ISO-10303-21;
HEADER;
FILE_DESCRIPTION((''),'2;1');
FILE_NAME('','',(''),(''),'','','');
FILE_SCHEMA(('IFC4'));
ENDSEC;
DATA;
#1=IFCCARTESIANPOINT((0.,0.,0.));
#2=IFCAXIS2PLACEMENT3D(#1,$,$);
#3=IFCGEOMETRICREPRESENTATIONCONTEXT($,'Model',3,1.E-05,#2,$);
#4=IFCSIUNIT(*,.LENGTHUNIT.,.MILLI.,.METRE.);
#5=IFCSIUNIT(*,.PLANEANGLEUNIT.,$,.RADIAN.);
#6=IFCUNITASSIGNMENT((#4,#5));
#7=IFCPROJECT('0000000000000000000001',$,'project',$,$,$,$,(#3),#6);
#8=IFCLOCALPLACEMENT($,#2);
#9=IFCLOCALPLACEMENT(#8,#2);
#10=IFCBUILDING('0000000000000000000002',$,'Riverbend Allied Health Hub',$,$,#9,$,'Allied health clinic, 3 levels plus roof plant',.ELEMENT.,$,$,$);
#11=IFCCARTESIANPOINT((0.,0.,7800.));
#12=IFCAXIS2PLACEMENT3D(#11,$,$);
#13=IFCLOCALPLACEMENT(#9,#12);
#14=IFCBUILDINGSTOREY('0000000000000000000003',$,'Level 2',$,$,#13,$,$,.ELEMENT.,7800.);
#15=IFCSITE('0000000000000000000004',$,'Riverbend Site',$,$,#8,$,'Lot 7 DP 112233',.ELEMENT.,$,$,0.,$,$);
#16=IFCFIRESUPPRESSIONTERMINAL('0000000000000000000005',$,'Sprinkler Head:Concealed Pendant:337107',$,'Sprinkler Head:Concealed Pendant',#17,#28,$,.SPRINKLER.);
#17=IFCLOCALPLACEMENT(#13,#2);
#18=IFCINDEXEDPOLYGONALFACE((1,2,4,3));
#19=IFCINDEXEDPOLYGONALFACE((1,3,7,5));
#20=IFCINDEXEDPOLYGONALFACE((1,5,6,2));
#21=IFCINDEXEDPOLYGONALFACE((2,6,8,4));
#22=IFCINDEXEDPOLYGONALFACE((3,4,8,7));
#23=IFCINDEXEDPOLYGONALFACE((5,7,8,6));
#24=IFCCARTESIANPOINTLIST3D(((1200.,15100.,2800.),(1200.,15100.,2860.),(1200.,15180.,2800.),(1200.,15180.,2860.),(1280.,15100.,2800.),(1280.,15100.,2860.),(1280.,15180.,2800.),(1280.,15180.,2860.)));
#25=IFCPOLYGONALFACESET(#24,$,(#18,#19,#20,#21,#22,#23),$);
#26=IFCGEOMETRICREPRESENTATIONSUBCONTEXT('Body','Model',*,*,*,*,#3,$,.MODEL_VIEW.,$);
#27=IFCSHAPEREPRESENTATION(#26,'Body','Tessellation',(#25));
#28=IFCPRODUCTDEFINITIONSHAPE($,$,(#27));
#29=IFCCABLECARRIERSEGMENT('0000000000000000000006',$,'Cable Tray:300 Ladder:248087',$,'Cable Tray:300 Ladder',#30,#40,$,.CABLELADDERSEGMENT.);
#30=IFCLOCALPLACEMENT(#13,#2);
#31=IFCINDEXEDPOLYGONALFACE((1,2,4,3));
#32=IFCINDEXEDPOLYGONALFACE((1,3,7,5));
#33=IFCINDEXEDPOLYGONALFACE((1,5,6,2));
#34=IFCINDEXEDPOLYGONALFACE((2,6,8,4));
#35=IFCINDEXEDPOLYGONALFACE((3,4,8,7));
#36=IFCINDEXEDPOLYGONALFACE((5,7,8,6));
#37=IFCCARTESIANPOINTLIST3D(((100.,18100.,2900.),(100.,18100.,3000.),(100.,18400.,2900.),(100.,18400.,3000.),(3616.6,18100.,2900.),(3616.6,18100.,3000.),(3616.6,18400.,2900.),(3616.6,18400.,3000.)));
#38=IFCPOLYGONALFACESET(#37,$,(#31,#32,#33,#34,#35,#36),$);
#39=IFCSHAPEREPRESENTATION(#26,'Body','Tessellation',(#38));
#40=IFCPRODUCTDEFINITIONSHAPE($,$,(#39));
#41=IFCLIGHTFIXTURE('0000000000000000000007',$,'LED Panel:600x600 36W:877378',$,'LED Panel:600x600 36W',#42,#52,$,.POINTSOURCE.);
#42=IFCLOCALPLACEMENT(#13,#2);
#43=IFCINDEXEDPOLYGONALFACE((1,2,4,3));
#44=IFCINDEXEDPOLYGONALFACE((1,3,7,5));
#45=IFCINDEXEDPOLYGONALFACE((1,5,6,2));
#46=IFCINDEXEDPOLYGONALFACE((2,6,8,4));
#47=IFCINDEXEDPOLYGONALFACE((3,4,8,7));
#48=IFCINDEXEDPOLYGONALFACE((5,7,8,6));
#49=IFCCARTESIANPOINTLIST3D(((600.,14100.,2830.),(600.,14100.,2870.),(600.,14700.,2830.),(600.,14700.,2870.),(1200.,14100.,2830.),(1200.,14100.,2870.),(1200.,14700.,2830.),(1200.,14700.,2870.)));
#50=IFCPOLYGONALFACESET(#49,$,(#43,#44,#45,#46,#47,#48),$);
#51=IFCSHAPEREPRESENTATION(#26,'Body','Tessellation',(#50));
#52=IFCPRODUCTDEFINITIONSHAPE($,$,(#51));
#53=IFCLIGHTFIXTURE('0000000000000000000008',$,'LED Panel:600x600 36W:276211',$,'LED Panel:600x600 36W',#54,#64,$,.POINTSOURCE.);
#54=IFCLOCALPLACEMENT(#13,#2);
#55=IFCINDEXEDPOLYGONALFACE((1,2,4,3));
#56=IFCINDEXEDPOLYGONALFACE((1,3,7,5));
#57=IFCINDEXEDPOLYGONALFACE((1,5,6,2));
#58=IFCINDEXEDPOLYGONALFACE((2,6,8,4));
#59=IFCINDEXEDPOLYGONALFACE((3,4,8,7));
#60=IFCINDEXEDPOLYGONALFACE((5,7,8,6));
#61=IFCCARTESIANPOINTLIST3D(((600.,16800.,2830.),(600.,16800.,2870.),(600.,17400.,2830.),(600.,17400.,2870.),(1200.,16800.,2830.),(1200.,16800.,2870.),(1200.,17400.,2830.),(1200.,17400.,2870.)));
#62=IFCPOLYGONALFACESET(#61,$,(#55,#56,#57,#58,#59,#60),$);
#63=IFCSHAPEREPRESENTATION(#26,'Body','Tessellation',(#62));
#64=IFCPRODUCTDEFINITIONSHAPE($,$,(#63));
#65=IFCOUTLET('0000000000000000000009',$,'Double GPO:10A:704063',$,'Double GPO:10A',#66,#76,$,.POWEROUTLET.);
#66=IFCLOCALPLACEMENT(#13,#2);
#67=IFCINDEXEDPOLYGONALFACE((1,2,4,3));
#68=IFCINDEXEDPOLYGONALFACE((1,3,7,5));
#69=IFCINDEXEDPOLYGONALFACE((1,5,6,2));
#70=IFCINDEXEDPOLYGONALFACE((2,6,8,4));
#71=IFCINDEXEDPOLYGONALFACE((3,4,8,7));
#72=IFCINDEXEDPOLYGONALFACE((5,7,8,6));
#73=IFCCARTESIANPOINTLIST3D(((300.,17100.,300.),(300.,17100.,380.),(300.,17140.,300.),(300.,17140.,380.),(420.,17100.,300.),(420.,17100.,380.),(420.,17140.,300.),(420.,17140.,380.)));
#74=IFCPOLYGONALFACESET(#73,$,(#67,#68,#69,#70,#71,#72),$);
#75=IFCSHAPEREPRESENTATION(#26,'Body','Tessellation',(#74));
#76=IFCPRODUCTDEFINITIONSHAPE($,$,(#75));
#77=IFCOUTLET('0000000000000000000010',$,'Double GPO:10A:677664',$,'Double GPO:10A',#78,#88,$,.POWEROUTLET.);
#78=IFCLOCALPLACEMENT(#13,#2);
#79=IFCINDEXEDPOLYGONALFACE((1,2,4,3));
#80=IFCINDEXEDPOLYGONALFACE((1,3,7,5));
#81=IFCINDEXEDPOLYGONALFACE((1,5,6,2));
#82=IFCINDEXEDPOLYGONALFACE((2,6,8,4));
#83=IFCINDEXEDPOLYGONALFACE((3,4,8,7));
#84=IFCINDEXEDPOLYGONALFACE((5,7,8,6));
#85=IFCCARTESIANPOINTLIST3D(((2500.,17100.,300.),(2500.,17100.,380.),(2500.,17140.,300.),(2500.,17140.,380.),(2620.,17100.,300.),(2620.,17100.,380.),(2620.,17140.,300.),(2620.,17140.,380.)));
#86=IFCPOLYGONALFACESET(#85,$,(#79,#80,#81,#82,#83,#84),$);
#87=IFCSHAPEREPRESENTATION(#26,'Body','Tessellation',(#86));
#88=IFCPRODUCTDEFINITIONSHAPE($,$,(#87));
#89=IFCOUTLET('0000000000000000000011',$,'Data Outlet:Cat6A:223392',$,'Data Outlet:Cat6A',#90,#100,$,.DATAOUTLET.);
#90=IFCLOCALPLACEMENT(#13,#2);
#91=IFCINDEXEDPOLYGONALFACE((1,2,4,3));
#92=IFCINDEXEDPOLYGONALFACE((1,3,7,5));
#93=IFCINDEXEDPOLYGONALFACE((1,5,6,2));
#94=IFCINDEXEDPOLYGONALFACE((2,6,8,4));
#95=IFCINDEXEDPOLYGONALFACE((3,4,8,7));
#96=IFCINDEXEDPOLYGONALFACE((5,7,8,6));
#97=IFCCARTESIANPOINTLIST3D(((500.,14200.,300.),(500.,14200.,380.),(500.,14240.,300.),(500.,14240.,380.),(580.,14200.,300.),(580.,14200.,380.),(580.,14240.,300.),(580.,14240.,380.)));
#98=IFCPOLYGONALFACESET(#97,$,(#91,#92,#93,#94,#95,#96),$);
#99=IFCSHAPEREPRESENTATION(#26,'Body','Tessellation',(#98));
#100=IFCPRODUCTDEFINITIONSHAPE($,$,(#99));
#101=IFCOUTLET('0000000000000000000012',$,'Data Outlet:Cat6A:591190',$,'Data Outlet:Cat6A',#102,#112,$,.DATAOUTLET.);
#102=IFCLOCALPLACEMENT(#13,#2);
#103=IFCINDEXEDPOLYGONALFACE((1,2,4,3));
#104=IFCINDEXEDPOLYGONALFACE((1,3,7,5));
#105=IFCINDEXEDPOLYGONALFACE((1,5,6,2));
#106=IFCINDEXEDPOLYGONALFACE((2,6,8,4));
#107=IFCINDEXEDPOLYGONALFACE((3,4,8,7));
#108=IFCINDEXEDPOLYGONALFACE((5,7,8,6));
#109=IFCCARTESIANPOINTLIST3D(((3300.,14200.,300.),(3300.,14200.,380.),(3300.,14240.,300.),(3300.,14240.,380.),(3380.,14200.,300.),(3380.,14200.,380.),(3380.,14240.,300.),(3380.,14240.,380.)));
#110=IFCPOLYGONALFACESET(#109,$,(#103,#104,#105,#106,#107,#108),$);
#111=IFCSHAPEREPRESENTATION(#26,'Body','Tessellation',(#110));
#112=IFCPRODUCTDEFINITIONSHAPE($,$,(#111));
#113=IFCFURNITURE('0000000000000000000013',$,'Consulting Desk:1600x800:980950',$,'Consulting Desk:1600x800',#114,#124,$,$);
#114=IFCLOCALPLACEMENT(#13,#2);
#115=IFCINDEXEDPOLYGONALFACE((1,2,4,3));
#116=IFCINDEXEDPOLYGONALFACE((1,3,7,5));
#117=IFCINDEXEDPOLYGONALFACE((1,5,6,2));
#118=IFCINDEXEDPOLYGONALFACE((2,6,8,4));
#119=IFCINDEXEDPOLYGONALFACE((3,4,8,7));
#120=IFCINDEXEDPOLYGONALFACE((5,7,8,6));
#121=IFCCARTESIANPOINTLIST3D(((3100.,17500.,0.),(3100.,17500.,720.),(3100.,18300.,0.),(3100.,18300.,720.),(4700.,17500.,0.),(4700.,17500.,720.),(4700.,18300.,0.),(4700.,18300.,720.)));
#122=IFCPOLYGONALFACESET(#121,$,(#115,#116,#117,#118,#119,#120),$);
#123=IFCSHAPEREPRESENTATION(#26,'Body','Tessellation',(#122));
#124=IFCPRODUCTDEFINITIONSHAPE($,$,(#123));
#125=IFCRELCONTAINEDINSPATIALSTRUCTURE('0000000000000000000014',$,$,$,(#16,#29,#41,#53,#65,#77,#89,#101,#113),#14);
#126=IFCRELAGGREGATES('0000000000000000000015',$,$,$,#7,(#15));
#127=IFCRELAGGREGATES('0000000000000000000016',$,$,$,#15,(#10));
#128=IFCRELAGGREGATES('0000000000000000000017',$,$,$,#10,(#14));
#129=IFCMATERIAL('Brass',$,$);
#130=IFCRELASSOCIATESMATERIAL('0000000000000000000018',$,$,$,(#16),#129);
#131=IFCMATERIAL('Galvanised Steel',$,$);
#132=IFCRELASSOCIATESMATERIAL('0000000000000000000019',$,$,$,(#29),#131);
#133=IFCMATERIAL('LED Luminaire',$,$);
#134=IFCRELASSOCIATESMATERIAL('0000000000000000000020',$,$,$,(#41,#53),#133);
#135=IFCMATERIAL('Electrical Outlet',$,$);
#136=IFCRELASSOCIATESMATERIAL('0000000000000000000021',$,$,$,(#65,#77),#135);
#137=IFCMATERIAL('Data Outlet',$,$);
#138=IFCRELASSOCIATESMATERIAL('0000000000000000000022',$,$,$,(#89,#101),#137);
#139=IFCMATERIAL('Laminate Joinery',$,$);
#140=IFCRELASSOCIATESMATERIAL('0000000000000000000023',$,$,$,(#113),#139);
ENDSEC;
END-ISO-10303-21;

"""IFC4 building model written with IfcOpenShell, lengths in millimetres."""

from ifc_helpers import new_model, si_unit, frame, frame_2d, origin, place, context, subcontext, project, spatial, rectangle, extrude, material, element, save


model = new_model("IFC4")

# Units and contexts
model_context = context("Model", 3, precision=1e-05, world=origin())
body_context = subcontext(model_context, "Body", "Model", "MODEL_VIEW")
ifc_project = project(units=[si_unit("LENGTHUNIT", "METRE", prefix="MILLI"), si_unit("PLANEANGLEUNIT", "RADIAN")], contexts=[model_context])

# Site, building, storey
site_placement = place(None, origin())
site = spatial("IfcSite", under=ifc_project, at=site_placement, Name="Riverbend Site", LongName="Lot 7 DP 112233", CompositionType="ELEMENT", RefElevation=0.0)
building_placement = place(site_placement, origin())
building = spatial("IfcBuilding", under=site, at=building_placement, Name="Riverbend Allied Health Hub", LongName="Allied health clinic, 3 levels plus roof plant", CompositionType="ELEMENT")
storey_placement = place(building_placement, frame((0.0, 0.0, 7800.0)))
storey = spatial("IfcBuildingStorey", under=building, at=storey_placement, Name="Level 2", CompositionType="ELEMENT", Elevation=7800.0)

# Shared definitions
ifc_material_1 = material(Name="Galvanised Steel")

# Fire suppression terminal
ifc_material_2 = material(Name="Brass")
fire_suppression_terminal_placement = place(storey_placement, frame((1200.0, 15100.0, 2800.0)))
element("IfcFireSuppressionTerminal", 1, at=fire_suppression_terminal_placement, inside=storey, material=ifc_material_2, Name="Sprinkler Head:Concealed Pendant:337107", ObjectType="Sprinkler Head:Concealed Pendant", PredefinedType="SPRINKLER", context=body_context, shape_type="SweptSolid", body=[
    extrude(rectangle(XDim=80.0, YDim=80.0, at=frame_2d((40.0, 40.0))), origin(), (0.0, 0.0, 1.0), 60.0),
])

# Cable carrier segment
cable_carrier_segment_placement = place(storey_placement, frame((100.0, 18100.0, 2900.0)))
element("IfcCableCarrierSegment", 2, at=cable_carrier_segment_placement, inside=storey, material=ifc_material_1, Name="Cable Tray:300 Ladder:248087", ObjectType="Cable Tray:300 Ladder", PredefinedType="CABLELADDERSEGMENT", context=body_context, shape_type="SweptSolid", body=[
    extrude(rectangle(XDim=3516.6, YDim=300.0, at=frame_2d((1758.3, 150.0))), origin(), (0.0, 0.0, 1.0), 100.0),
])

# Light fixtures
ifc_material_3 = material(Name="LED Luminaire")
for number, where, name in (
    (3, (600.0, 14100.0, 2830.0), "LED Panel:600x600 36W:877378"),
    (4, (600.0, 16800.0, 2830.0), "LED Panel:600x600 36W:276211"),
):
    element("IfcLightFixture", number, at=place(storey_placement, frame(where)), inside=storey, material=ifc_material_3, Name=name, ObjectType="LED Panel:600x600 36W", PredefinedType="POINTSOURCE", context=body_context, shape_type="SweptSolid", body=[
        extrude(rectangle(XDim=600.0, YDim=600.0, at=frame_2d((300.0, 300.0))), origin(), (0.0, 0.0, 1.0), 40.0),
    ])

# Outlets
ifc_material_4 = material(Name="Electrical Outlet")
for number, where, name in (
    (5, (300.0, 17100.0, 300.0), "Double GPO:10A:704063"),
    (6, (2500.0, 17100.0, 300.0), "Double GPO:10A:677664"),
):
    element("IfcOutlet", number, at=place(storey_placement, frame(where)), inside=storey, material=ifc_material_4, Name=name, ObjectType="Double GPO:10A", PredefinedType="POWEROUTLET", context=body_context, shape_type="SweptSolid", body=[
        extrude(rectangle(XDim=120.0, YDim=40.0, at=frame_2d((60.0, 20.0))), origin(), (0.0, 0.0, 1.0), 80.0),
    ])
ifc_material_5 = material(Name="Data Outlet")
for number, where, name in (
    (7, (500.0, 14200.0, 300.0), "Data Outlet:Cat6A:223392"),
    (8, (3300.0, 14200.0, 300.0), "Data Outlet:Cat6A:591190"),
):
    element("IfcOutlet", number, at=place(storey_placement, frame(where)), inside=storey, material=ifc_material_5, Name=name, ObjectType="Data Outlet:Cat6A", PredefinedType="DATAOUTLET", context=body_context, shape_type="SweptSolid", body=[
        extrude(rectangle(XDim=80.0, YDim=40.0, at=frame_2d((40.0, 20.0))), origin(), (0.0, 0.0, 1.0), 80.0),
    ])

# Furniture
ifc_material_6 = material(Name="Laminate Joinery")
furniture_placement = place(storey_placement, frame((3100.0, 17500.0, 0.0)))
element("IfcFurniture", 9, at=furniture_placement, inside=storey, material=ifc_material_6, Name="Consulting Desk:1600x800:980950", ObjectType="Consulting Desk:1600x800", context=body_context, shape_type="SweptSolid", body=[
    extrude(rectangle(XDim=1600.0, YDim=800.0, at=frame_2d((800.0, 400.0))), origin(), (0.0, 0.0, 1.0), 720.0),
])

save(model, "model.ifc")
